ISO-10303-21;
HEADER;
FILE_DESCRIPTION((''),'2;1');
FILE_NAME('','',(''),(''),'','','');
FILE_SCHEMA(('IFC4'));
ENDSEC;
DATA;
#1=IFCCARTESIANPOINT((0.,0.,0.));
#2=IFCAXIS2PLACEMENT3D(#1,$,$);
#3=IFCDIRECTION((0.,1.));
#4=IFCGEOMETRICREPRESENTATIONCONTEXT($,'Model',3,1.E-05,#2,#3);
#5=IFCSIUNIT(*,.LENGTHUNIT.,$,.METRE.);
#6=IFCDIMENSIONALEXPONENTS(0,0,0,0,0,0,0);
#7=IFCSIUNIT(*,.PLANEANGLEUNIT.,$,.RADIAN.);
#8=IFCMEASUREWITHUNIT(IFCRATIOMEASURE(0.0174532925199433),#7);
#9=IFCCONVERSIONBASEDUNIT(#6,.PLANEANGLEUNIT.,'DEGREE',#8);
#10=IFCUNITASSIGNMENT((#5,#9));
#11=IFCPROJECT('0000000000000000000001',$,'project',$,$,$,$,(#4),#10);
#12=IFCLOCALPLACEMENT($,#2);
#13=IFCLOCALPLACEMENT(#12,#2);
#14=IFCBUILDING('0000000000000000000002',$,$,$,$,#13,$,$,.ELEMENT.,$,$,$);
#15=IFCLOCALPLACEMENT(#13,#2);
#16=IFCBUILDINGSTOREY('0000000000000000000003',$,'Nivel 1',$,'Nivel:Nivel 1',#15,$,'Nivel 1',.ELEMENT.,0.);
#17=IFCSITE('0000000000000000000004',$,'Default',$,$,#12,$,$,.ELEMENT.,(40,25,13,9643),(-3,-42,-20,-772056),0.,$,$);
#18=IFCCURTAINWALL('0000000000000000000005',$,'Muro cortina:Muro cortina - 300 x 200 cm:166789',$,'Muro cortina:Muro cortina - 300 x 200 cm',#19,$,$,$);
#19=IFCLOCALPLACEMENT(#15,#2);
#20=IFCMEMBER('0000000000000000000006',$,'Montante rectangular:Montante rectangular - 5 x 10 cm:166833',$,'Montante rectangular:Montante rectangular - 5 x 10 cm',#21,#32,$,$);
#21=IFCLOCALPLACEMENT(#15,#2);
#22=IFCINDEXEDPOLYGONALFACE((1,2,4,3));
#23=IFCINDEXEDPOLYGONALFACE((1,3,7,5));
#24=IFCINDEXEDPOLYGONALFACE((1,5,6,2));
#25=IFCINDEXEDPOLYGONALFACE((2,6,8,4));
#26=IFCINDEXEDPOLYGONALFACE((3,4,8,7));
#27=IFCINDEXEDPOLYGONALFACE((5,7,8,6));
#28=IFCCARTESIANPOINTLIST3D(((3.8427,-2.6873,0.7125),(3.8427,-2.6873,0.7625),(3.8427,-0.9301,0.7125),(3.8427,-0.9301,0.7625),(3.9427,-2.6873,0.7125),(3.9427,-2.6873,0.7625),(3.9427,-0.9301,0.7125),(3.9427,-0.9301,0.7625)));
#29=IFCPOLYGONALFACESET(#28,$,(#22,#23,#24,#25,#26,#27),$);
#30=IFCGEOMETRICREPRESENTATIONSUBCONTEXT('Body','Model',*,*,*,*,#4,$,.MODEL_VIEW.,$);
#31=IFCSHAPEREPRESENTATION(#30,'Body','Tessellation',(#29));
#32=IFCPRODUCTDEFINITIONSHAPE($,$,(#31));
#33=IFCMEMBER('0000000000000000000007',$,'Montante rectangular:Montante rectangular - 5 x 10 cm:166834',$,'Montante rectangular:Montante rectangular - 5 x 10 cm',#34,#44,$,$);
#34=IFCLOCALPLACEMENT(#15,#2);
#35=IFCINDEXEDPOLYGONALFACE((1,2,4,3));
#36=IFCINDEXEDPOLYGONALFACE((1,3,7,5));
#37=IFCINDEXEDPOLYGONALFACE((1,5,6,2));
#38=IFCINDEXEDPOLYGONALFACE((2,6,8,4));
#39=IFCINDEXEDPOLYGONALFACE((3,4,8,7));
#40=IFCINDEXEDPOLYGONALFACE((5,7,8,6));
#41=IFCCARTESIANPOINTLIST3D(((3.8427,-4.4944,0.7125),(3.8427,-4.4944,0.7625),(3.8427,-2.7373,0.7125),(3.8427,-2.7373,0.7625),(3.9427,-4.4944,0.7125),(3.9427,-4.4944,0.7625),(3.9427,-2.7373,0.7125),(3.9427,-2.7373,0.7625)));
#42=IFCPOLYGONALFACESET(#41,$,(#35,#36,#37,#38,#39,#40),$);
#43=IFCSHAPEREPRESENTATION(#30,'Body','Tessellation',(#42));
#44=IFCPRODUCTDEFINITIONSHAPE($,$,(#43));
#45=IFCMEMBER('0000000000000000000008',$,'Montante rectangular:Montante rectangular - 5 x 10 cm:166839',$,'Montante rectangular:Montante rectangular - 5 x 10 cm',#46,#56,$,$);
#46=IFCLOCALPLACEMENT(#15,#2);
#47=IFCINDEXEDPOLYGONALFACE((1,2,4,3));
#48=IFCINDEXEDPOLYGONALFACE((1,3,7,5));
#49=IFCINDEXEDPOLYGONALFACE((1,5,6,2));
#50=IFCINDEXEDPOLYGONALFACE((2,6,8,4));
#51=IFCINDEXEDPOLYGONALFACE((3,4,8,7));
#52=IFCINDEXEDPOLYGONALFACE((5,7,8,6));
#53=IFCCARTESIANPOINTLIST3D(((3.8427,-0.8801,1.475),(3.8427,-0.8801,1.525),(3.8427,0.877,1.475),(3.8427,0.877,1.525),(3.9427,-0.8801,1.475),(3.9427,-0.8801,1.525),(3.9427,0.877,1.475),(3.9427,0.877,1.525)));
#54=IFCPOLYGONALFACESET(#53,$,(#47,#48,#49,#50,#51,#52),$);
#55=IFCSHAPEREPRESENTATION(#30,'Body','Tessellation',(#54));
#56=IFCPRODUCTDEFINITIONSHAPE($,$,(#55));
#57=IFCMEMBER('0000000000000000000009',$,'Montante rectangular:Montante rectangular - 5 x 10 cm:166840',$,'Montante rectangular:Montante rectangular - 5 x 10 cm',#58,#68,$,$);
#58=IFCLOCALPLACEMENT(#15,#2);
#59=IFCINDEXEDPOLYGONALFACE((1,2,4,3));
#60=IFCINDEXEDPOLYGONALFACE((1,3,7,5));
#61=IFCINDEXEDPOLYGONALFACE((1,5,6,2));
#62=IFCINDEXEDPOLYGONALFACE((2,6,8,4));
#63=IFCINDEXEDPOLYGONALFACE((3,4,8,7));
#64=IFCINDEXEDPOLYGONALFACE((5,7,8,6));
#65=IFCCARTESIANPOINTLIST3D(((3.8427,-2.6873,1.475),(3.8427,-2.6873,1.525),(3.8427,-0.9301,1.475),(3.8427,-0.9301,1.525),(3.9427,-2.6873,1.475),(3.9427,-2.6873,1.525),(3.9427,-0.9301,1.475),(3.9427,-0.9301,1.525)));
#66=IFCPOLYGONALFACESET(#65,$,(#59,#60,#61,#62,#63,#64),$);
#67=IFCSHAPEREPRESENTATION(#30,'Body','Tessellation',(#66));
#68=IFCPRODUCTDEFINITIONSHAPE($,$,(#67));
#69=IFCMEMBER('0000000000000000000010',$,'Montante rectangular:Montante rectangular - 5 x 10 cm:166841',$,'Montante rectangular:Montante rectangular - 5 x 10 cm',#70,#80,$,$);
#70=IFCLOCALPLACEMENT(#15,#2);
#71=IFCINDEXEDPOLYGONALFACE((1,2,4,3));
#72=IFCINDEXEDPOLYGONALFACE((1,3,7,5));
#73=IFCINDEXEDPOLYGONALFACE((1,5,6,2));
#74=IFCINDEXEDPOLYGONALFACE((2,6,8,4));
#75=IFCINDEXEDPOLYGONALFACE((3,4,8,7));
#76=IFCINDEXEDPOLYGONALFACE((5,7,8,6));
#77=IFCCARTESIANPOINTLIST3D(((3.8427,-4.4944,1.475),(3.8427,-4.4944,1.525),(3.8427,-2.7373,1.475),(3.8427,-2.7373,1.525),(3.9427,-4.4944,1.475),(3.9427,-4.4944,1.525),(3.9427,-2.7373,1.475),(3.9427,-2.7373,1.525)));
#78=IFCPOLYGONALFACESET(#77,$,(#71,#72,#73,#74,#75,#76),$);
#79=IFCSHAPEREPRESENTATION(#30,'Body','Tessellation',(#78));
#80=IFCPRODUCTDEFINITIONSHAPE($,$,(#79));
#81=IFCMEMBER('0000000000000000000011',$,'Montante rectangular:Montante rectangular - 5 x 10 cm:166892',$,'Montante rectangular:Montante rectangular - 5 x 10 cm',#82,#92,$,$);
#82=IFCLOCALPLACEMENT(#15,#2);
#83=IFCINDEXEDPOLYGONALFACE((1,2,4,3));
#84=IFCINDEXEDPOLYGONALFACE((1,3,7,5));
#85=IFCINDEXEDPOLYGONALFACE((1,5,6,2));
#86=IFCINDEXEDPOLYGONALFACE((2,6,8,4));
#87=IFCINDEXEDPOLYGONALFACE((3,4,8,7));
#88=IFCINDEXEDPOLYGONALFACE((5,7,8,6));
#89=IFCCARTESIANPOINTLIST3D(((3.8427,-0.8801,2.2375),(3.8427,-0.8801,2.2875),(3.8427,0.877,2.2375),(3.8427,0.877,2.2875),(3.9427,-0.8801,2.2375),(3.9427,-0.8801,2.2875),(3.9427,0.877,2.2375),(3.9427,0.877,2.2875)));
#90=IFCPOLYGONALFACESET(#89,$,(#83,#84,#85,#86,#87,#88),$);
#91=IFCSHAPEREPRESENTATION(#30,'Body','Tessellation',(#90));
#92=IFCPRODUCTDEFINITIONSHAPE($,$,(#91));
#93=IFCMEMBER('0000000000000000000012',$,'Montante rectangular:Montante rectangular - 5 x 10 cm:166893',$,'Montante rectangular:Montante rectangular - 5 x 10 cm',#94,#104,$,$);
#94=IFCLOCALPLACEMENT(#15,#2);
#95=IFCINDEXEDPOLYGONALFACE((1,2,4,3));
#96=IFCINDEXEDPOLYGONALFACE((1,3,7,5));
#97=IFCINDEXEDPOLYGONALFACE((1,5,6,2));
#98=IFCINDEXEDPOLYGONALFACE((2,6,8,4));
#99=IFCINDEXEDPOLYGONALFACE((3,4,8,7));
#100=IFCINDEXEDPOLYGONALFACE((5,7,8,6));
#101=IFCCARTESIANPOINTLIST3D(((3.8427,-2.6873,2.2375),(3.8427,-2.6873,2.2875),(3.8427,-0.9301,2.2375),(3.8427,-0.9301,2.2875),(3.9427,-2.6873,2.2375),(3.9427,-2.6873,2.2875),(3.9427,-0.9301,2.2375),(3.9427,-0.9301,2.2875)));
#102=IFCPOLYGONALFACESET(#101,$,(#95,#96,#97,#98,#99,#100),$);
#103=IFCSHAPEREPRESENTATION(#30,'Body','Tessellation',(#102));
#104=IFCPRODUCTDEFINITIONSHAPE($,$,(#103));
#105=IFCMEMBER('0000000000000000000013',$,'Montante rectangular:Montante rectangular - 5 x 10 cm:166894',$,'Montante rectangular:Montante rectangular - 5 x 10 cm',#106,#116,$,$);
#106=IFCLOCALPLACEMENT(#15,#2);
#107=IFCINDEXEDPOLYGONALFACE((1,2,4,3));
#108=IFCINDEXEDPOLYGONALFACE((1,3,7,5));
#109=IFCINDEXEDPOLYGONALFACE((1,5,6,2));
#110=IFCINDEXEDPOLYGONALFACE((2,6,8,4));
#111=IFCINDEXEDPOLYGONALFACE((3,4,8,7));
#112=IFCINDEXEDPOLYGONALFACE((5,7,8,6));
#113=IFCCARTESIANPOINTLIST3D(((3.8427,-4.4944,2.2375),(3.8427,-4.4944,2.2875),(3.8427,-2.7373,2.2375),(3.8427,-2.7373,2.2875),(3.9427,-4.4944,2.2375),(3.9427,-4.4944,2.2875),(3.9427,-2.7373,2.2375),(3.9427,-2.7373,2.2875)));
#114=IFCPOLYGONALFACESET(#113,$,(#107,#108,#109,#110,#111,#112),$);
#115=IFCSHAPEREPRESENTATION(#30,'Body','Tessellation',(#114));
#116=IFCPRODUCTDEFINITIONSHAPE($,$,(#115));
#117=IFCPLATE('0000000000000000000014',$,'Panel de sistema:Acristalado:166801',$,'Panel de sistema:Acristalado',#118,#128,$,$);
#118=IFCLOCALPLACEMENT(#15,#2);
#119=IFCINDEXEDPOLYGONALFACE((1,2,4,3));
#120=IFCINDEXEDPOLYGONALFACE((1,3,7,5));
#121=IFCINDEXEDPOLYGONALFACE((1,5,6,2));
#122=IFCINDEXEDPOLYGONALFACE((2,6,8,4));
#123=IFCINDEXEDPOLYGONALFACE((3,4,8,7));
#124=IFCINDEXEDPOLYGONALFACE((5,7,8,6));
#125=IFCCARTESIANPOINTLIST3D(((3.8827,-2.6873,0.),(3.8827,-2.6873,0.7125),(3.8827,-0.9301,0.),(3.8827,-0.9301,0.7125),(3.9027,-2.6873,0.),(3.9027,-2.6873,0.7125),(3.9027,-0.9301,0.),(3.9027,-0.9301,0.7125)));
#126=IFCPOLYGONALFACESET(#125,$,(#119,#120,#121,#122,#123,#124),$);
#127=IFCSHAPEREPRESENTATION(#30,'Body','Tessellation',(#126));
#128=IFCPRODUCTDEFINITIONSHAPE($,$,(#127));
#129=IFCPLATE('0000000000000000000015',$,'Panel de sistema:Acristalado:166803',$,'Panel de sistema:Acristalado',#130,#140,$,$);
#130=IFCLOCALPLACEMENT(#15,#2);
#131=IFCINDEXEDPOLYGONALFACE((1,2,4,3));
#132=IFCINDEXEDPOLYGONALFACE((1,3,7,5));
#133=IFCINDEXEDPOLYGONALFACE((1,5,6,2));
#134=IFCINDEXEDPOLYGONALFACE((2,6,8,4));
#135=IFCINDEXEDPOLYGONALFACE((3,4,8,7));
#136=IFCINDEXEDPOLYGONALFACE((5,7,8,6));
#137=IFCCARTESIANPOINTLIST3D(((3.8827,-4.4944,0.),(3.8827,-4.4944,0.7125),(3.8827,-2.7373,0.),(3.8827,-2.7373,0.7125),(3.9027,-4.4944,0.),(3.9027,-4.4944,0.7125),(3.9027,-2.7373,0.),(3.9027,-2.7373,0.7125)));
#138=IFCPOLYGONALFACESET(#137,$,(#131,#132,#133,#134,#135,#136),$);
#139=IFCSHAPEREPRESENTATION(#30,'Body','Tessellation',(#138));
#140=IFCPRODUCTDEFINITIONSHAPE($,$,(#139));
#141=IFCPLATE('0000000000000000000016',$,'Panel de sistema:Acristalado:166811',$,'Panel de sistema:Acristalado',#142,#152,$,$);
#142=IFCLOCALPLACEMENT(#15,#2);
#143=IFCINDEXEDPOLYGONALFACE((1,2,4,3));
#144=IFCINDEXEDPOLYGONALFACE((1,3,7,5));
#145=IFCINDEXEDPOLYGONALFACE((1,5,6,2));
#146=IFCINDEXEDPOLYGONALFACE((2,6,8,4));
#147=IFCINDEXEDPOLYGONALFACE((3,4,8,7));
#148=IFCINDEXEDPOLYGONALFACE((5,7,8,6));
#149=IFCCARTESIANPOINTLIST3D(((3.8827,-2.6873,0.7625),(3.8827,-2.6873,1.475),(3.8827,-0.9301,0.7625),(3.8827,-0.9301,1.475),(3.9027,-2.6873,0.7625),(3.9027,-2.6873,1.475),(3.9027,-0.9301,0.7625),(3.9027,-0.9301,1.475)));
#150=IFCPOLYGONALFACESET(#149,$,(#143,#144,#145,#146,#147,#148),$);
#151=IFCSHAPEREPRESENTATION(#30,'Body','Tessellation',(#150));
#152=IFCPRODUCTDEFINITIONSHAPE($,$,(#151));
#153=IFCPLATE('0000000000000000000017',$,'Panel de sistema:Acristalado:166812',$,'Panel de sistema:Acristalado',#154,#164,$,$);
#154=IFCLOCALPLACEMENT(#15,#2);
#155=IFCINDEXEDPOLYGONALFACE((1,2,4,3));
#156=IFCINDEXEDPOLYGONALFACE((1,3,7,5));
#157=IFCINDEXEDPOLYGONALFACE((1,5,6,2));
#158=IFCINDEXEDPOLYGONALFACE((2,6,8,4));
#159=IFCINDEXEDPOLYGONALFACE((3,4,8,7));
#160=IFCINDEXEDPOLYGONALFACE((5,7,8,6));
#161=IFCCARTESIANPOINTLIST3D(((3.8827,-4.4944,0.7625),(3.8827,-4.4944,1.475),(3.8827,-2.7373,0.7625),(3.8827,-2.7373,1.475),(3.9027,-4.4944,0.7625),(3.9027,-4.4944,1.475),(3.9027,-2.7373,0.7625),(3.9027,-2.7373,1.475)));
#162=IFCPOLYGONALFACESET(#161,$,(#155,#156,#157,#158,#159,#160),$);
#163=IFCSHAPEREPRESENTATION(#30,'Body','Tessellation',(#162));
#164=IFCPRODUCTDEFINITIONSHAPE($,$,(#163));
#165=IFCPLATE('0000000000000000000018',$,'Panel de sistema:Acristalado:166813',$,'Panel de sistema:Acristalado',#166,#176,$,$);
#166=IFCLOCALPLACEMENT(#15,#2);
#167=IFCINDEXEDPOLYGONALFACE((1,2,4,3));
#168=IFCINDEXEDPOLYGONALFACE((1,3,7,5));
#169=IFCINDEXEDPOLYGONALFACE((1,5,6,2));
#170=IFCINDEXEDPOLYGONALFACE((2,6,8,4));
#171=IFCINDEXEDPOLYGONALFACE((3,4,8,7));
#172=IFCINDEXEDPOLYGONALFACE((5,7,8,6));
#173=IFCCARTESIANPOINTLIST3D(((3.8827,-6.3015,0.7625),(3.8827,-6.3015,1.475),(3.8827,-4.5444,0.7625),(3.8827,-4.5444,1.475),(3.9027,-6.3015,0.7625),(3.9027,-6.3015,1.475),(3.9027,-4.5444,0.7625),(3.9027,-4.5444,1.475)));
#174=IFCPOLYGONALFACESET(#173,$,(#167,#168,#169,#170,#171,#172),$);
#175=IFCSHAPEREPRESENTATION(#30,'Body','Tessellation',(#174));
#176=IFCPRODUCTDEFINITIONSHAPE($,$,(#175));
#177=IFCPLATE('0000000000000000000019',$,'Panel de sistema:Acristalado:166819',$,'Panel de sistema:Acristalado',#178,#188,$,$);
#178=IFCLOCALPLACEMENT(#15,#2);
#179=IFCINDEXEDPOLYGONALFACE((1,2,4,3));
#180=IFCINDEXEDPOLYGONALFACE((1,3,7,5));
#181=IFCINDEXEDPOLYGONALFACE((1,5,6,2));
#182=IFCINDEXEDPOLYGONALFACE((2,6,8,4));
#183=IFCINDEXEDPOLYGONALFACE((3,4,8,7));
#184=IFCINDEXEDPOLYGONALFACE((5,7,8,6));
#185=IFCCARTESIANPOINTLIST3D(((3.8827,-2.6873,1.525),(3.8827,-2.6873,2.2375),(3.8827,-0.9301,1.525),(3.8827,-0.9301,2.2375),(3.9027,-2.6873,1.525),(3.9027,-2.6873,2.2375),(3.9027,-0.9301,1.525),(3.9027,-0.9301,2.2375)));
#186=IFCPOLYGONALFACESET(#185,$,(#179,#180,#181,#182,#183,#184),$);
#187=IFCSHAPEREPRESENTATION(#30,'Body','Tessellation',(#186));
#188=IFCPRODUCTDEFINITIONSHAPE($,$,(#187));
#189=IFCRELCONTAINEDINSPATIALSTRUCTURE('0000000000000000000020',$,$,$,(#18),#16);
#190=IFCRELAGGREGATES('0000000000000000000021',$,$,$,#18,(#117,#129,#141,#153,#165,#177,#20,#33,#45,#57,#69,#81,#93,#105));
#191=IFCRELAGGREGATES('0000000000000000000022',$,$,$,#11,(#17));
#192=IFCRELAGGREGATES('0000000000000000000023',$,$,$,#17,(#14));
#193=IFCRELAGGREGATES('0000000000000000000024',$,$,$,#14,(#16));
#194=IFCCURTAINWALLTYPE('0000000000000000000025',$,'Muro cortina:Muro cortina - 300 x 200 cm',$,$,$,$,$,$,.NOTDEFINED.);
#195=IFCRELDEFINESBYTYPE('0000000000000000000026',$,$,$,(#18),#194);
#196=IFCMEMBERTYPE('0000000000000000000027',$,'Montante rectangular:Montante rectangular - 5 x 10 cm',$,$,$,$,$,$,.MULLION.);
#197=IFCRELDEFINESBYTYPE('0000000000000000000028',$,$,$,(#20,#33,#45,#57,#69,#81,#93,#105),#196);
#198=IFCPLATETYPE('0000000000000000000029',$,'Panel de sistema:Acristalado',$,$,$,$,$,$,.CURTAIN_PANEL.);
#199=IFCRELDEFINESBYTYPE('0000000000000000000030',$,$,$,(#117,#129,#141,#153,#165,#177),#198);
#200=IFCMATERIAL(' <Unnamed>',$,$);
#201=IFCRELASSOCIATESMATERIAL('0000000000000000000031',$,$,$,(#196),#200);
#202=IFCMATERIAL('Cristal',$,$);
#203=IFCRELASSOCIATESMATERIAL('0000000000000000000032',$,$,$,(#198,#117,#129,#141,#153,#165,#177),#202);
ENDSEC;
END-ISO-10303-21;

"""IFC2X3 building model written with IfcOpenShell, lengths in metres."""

from ifc_helpers import new_model, entity, si_unit, converted_unit, direction, frame, origin, origin_2d_with_axis, place, context, subcontext, project, spatial, rectangle, extrude, source, transform, mapped, material, type_object, type_shapes, element, aggregate, save


model = new_model("IFC2X3")

# Units and contexts
model_context = context("Model", 3, precision=1e-05, world=origin(), true_north=direction((0.0, 1.0)))
body_context = subcontext(model_context, "Body", "Model", "MODEL_VIEW")
ifc_project = project(units=[si_unit("LENGTHUNIT", "METRE"), converted_unit("PLANEANGLEUNIT", "DEGREE", entity("IfcRatioMeasure", 0.0174532925199433), si_unit("PLANEANGLEUNIT", "RADIAN"), dimensions=[0, 0, 0, 0, 0, 0, 0])], contexts=[model_context])

# Site, building, storey
site_placement = place(None, origin())
site = spatial("IfcSite", under=ifc_project, at=site_placement, Name="Default", CompositionType="ELEMENT", RefLatitude=(40, 25, 13, 9643), RefLongitude=(-3, -42, -20, -772056), RefElevation=0.0)
building_placement = place(site_placement, origin())
building = spatial("IfcBuilding", under=site, at=building_placement, CompositionType="ELEMENT")
storey_placement = place(building_placement, origin())
storey = spatial("IfcBuildingStorey", under=building, at=storey_placement, Name="Nivel 1", ObjectType="Nivel:Nivel 1", LongName="Nivel 1", CompositionType="ELEMENT", Elevation=0.0)

# Curtain wall, members, plates
curtain_wall_type = type_object("IfcCurtainWallType", Name="Muro cortina:Muro cortina - 300 x 200 cm", PredefinedType="NOTDEFINED")
curtain_wall_placement = place(storey_placement, origin())
curtain_wall = element("IfcCurtainWall", 1, at=curtain_wall_placement, inside=storey, type_object=curtain_wall_type, Name="Muro cortina:Muro cortina - 300 x 200 cm:166789", ObjectType="Muro cortina:Muro cortina - 300 x 200 cm")
ifc_material_1 = material(Name=" <Unnamed>")
member_type_1 = type_object("IfcMemberType", Name="Montante rectangular:Montante rectangular - 5 x 10 cm", PredefinedType="MULLION", material=ifc_material_1)
shared_shape_1 = source(origin(), body_context, "Body", "SweptSolid", [
    extrude(rectangle(XDim=0.1, YDim=0.05, at=origin_2d_with_axis()), frame((0.0, 0.0, -1.7571), z_axis=(0.0, 0.0, 1.0), x_axis=(0.0, -1.0, 0.0)), (0.0, 0.0, 1.0), 1.7571),
])
type_shapes(member_type_1, [shared_shape_1])
member_1_placement = place(storey_placement, frame((3.8927, -2.6873, 0.7375), z_axis=(0.0, -1.0, 0.0), x_axis=(0.0, 0.0, 1.0)))
member_1 = element("IfcMember", 2, at=member_1_placement, type_object=member_type_1, Name="Montante rectangular:Montante rectangular - 5 x 10 cm:166833", ObjectType="Montante rectangular:Montante rectangular - 5 x 10 cm", context=body_context, shape_type="MappedRepresentation", body=[
    mapped(shared_shape_1, transform((0.0, 0.0, 0.0), scale=1.0)),
])
member_2_placement = place(storey_placement, frame((3.8927, -4.4944, 0.7375), z_axis=(0.0, -1.0, 0.0), x_axis=(0.0, 0.0, 1.0)))
member_2 = element("IfcMember", 3, at=member_2_placement, type_object=member_type_1, Name="Montante rectangular:Montante rectangular - 5 x 10 cm:166834", ObjectType="Montante rectangular:Montante rectangular - 5 x 10 cm", context=body_context, shape_type="MappedRepresentation", body=[
    mapped(shared_shape_1, transform((0.0, 0.0, 0.0), scale=1.0)),
])
member_3_placement = place(storey_placement, frame((3.8927, -0.8801, 1.5), z_axis=(0.0, -1.0, 0.0), x_axis=(0.0, 0.0, 1.0)))
member_3 = element("IfcMember", 4, at=member_3_placement, type_object=member_type_1, Name="Montante rectangular:Montante rectangular - 5 x 10 cm:166839", ObjectType="Montante rectangular:Montante rectangular - 5 x 10 cm", context=body_context, shape_type="MappedRepresentation", body=[
    mapped(shared_shape_1, transform((0.0, 0.0, 0.0), scale=1.0)),
])
member_4_placement = place(storey_placement, frame((3.8927, -2.6873, 1.5), z_axis=(0.0, -1.0, 0.0), x_axis=(0.0, 0.0, 1.0)))
member_4 = element("IfcMember", 5, at=member_4_placement, type_object=member_type_1, Name="Montante rectangular:Montante rectangular - 5 x 10 cm:166840", ObjectType="Montante rectangular:Montante rectangular - 5 x 10 cm", context=body_context, shape_type="MappedRepresentation", body=[
    mapped(shared_shape_1, transform((0.0, 0.0, 0.0), scale=1.0)),
])
member_5_placement = place(storey_placement, frame((3.8927, -4.4944, 1.5), z_axis=(0.0, -1.0, 0.0), x_axis=(0.0, 0.0, 1.0)))
member_5 = element("IfcMember", 6, at=member_5_placement, type_object=member_type_1, Name="Montante rectangular:Montante rectangular - 5 x 10 cm:166841", ObjectType="Montante rectangular:Montante rectangular - 5 x 10 cm", context=body_context, shape_type="MappedRepresentation", body=[
    mapped(shared_shape_1, transform((0.0, 0.0, 0.0), scale=1.0)),
])
member_6_placement = place(storey_placement, frame((3.8927, -0.8801, 2.2625), z_axis=(0.0, -1.0, 0.0), x_axis=(0.0, 0.0, 1.0)))
member_6 = element("IfcMember", 7, at=member_6_placement, type_object=member_type_1, Name="Montante rectangular:Montante rectangular - 5 x 10 cm:166892", ObjectType="Montante rectangular:Montante rectangular - 5 x 10 cm", context=body_context, shape_type="MappedRepresentation", body=[
    mapped(shared_shape_1, transform((0.0, 0.0, 0.0), scale=1.0)),
])
member_7_placement = place(storey_placement, frame((3.8927, -2.6873, 2.2625), z_axis=(0.0, -1.0, 0.0), x_axis=(0.0, 0.0, 1.0)))
member_7 = element("IfcMember", 8, at=member_7_placement, type_object=member_type_1, Name="Montante rectangular:Montante rectangular - 5 x 10 cm:166893", ObjectType="Montante rectangular:Montante rectangular - 5 x 10 cm", context=body_context, shape_type="MappedRepresentation", body=[
    mapped(shared_shape_1, transform((0.0, 0.0, 0.0), scale=1.0)),
])
member_8_placement = place(storey_placement, frame((3.8927, -4.4944, 2.2625), z_axis=(0.0, -1.0, 0.0), x_axis=(0.0, 0.0, 1.0)))
member_8 = element("IfcMember", 9, at=member_8_placement, type_object=member_type_1, Name="Montante rectangular:Montante rectangular - 5 x 10 cm:166894", ObjectType="Montante rectangular:Montante rectangular - 5 x 10 cm", context=body_context, shape_type="MappedRepresentation", body=[
    mapped(shared_shape_1, transform((0.0, 0.0, 0.0), scale=1.0)),
])
ifc_material_2 = material(Name="Cristal")
plate_type = type_object("IfcPlateType", Name="Panel de sistema:Acristalado", PredefinedType="CURTAIN_PANEL", material=ifc_material_2)
shared_shape_2 = source(origin(), body_context, "Body", "SweptSolid", [
    extrude(rectangle(XDim=0.02, YDim=1.7571, at=origin_2d_with_axis()), frame((0.0, 0.0, 0.0), z_axis=(0.0, 0.0, 1.0), x_axis=(0.0, 1.0, 0.0)), (0.0, 0.0, 1.0), 0.7125),
])
type_shapes(plate_type, [shared_shape_2])
plate_1_placement = place(curtain_wall_placement, frame((3.8927, -1.8087, 0.0), z_axis=(0.0, 0.0, 1.0), x_axis=(0.0, -1.0, 0.0)))
plate_1 = element("IfcPlate", 10, at=plate_1_placement, type_object=plate_type, material=ifc_material_2, Name="Panel de sistema:Acristalado:166801", ObjectType="Panel de sistema:Acristalado", context=body_context, shape_type="MappedRepresentation", body=[
    mapped(shared_shape_2, transform((0.0, 0.0, 0.0), scale=1.0)),
])
plate_2_placement = place(curtain_wall_placement, frame((3.8927, -3.6158, 0.0), z_axis=(0.0, 0.0, 1.0), x_axis=(0.0, -1.0, 0.0)))
plate_2 = element("IfcPlate", 11, at=plate_2_placement, type_object=plate_type, material=ifc_material_2, Name="Panel de sistema:Acristalado:166803", ObjectType="Panel de sistema:Acristalado", context=body_context, shape_type="MappedRepresentation", body=[
    mapped(shared_shape_2, transform((0.0, 0.0, 0.0), scale=1.0)),
])
plate_3_placement = place(curtain_wall_placement, frame((3.8927, -1.8087, 0.7625), z_axis=(0.0, 0.0, 1.0), x_axis=(0.0, -1.0, 0.0)))
plate_3 = element("IfcPlate", 12, at=plate_3_placement, type_object=plate_type, material=ifc_material_2, Name="Panel de sistema:Acristalado:166811", ObjectType="Panel de sistema:Acristalado", context=body_context, shape_type="MappedRepresentation", body=[
    mapped(shared_shape_2, transform((0.0, 0.0, 0.0), scale=1.0)),
])
plate_4_placement = place(curtain_wall_placement, frame((3.8927, -3.6158, 0.7625), z_axis=(0.0, 0.0, 1.0), x_axis=(0.0, -1.0, 0.0)))
plate_4 = element("IfcPlate", 13, at=plate_4_placement, type_object=plate_type, material=ifc_material_2, Name="Panel de sistema:Acristalado:166812", ObjectType="Panel de sistema:Acristalado", context=body_context, shape_type="MappedRepresentation", body=[
    mapped(shared_shape_2, transform((0.0, 0.0, 0.0), scale=1.0)),
])
plate_5_placement = place(curtain_wall_placement, frame((3.8927, -5.423, 0.7625), z_axis=(0.0, 0.0, 1.0), x_axis=(0.0, -1.0, 0.0)))
plate_5 = element("IfcPlate", 14, at=plate_5_placement, type_object=plate_type, material=ifc_material_2, Name="Panel de sistema:Acristalado:166813", ObjectType="Panel de sistema:Acristalado", context=body_context, shape_type="MappedRepresentation", body=[
    mapped(shared_shape_2, transform((0.0, 0.0, 0.0), scale=1.0)),
])
plate_6_placement = place(curtain_wall_placement, frame((3.8927, -1.8087, 1.525), z_axis=(0.0, 0.0, 1.0), x_axis=(0.0, -1.0, 0.0)))
plate_6 = element("IfcPlate", 15, at=plate_6_placement, type_object=plate_type, material=ifc_material_2, Name="Panel de sistema:Acristalado:166819", ObjectType="Panel de sistema:Acristalado", context=body_context, shape_type="MappedRepresentation", body=[
    mapped(shared_shape_2, transform((0.0, 0.0, 0.0), scale=1.0)),
])
aggregate(curtain_wall, [plate_1, plate_2, plate_3, plate_4, plate_5, plate_6, member_1, member_2, member_3, member_4, member_5, member_6, member_7, member_8])

save(model, "model.ifc")
